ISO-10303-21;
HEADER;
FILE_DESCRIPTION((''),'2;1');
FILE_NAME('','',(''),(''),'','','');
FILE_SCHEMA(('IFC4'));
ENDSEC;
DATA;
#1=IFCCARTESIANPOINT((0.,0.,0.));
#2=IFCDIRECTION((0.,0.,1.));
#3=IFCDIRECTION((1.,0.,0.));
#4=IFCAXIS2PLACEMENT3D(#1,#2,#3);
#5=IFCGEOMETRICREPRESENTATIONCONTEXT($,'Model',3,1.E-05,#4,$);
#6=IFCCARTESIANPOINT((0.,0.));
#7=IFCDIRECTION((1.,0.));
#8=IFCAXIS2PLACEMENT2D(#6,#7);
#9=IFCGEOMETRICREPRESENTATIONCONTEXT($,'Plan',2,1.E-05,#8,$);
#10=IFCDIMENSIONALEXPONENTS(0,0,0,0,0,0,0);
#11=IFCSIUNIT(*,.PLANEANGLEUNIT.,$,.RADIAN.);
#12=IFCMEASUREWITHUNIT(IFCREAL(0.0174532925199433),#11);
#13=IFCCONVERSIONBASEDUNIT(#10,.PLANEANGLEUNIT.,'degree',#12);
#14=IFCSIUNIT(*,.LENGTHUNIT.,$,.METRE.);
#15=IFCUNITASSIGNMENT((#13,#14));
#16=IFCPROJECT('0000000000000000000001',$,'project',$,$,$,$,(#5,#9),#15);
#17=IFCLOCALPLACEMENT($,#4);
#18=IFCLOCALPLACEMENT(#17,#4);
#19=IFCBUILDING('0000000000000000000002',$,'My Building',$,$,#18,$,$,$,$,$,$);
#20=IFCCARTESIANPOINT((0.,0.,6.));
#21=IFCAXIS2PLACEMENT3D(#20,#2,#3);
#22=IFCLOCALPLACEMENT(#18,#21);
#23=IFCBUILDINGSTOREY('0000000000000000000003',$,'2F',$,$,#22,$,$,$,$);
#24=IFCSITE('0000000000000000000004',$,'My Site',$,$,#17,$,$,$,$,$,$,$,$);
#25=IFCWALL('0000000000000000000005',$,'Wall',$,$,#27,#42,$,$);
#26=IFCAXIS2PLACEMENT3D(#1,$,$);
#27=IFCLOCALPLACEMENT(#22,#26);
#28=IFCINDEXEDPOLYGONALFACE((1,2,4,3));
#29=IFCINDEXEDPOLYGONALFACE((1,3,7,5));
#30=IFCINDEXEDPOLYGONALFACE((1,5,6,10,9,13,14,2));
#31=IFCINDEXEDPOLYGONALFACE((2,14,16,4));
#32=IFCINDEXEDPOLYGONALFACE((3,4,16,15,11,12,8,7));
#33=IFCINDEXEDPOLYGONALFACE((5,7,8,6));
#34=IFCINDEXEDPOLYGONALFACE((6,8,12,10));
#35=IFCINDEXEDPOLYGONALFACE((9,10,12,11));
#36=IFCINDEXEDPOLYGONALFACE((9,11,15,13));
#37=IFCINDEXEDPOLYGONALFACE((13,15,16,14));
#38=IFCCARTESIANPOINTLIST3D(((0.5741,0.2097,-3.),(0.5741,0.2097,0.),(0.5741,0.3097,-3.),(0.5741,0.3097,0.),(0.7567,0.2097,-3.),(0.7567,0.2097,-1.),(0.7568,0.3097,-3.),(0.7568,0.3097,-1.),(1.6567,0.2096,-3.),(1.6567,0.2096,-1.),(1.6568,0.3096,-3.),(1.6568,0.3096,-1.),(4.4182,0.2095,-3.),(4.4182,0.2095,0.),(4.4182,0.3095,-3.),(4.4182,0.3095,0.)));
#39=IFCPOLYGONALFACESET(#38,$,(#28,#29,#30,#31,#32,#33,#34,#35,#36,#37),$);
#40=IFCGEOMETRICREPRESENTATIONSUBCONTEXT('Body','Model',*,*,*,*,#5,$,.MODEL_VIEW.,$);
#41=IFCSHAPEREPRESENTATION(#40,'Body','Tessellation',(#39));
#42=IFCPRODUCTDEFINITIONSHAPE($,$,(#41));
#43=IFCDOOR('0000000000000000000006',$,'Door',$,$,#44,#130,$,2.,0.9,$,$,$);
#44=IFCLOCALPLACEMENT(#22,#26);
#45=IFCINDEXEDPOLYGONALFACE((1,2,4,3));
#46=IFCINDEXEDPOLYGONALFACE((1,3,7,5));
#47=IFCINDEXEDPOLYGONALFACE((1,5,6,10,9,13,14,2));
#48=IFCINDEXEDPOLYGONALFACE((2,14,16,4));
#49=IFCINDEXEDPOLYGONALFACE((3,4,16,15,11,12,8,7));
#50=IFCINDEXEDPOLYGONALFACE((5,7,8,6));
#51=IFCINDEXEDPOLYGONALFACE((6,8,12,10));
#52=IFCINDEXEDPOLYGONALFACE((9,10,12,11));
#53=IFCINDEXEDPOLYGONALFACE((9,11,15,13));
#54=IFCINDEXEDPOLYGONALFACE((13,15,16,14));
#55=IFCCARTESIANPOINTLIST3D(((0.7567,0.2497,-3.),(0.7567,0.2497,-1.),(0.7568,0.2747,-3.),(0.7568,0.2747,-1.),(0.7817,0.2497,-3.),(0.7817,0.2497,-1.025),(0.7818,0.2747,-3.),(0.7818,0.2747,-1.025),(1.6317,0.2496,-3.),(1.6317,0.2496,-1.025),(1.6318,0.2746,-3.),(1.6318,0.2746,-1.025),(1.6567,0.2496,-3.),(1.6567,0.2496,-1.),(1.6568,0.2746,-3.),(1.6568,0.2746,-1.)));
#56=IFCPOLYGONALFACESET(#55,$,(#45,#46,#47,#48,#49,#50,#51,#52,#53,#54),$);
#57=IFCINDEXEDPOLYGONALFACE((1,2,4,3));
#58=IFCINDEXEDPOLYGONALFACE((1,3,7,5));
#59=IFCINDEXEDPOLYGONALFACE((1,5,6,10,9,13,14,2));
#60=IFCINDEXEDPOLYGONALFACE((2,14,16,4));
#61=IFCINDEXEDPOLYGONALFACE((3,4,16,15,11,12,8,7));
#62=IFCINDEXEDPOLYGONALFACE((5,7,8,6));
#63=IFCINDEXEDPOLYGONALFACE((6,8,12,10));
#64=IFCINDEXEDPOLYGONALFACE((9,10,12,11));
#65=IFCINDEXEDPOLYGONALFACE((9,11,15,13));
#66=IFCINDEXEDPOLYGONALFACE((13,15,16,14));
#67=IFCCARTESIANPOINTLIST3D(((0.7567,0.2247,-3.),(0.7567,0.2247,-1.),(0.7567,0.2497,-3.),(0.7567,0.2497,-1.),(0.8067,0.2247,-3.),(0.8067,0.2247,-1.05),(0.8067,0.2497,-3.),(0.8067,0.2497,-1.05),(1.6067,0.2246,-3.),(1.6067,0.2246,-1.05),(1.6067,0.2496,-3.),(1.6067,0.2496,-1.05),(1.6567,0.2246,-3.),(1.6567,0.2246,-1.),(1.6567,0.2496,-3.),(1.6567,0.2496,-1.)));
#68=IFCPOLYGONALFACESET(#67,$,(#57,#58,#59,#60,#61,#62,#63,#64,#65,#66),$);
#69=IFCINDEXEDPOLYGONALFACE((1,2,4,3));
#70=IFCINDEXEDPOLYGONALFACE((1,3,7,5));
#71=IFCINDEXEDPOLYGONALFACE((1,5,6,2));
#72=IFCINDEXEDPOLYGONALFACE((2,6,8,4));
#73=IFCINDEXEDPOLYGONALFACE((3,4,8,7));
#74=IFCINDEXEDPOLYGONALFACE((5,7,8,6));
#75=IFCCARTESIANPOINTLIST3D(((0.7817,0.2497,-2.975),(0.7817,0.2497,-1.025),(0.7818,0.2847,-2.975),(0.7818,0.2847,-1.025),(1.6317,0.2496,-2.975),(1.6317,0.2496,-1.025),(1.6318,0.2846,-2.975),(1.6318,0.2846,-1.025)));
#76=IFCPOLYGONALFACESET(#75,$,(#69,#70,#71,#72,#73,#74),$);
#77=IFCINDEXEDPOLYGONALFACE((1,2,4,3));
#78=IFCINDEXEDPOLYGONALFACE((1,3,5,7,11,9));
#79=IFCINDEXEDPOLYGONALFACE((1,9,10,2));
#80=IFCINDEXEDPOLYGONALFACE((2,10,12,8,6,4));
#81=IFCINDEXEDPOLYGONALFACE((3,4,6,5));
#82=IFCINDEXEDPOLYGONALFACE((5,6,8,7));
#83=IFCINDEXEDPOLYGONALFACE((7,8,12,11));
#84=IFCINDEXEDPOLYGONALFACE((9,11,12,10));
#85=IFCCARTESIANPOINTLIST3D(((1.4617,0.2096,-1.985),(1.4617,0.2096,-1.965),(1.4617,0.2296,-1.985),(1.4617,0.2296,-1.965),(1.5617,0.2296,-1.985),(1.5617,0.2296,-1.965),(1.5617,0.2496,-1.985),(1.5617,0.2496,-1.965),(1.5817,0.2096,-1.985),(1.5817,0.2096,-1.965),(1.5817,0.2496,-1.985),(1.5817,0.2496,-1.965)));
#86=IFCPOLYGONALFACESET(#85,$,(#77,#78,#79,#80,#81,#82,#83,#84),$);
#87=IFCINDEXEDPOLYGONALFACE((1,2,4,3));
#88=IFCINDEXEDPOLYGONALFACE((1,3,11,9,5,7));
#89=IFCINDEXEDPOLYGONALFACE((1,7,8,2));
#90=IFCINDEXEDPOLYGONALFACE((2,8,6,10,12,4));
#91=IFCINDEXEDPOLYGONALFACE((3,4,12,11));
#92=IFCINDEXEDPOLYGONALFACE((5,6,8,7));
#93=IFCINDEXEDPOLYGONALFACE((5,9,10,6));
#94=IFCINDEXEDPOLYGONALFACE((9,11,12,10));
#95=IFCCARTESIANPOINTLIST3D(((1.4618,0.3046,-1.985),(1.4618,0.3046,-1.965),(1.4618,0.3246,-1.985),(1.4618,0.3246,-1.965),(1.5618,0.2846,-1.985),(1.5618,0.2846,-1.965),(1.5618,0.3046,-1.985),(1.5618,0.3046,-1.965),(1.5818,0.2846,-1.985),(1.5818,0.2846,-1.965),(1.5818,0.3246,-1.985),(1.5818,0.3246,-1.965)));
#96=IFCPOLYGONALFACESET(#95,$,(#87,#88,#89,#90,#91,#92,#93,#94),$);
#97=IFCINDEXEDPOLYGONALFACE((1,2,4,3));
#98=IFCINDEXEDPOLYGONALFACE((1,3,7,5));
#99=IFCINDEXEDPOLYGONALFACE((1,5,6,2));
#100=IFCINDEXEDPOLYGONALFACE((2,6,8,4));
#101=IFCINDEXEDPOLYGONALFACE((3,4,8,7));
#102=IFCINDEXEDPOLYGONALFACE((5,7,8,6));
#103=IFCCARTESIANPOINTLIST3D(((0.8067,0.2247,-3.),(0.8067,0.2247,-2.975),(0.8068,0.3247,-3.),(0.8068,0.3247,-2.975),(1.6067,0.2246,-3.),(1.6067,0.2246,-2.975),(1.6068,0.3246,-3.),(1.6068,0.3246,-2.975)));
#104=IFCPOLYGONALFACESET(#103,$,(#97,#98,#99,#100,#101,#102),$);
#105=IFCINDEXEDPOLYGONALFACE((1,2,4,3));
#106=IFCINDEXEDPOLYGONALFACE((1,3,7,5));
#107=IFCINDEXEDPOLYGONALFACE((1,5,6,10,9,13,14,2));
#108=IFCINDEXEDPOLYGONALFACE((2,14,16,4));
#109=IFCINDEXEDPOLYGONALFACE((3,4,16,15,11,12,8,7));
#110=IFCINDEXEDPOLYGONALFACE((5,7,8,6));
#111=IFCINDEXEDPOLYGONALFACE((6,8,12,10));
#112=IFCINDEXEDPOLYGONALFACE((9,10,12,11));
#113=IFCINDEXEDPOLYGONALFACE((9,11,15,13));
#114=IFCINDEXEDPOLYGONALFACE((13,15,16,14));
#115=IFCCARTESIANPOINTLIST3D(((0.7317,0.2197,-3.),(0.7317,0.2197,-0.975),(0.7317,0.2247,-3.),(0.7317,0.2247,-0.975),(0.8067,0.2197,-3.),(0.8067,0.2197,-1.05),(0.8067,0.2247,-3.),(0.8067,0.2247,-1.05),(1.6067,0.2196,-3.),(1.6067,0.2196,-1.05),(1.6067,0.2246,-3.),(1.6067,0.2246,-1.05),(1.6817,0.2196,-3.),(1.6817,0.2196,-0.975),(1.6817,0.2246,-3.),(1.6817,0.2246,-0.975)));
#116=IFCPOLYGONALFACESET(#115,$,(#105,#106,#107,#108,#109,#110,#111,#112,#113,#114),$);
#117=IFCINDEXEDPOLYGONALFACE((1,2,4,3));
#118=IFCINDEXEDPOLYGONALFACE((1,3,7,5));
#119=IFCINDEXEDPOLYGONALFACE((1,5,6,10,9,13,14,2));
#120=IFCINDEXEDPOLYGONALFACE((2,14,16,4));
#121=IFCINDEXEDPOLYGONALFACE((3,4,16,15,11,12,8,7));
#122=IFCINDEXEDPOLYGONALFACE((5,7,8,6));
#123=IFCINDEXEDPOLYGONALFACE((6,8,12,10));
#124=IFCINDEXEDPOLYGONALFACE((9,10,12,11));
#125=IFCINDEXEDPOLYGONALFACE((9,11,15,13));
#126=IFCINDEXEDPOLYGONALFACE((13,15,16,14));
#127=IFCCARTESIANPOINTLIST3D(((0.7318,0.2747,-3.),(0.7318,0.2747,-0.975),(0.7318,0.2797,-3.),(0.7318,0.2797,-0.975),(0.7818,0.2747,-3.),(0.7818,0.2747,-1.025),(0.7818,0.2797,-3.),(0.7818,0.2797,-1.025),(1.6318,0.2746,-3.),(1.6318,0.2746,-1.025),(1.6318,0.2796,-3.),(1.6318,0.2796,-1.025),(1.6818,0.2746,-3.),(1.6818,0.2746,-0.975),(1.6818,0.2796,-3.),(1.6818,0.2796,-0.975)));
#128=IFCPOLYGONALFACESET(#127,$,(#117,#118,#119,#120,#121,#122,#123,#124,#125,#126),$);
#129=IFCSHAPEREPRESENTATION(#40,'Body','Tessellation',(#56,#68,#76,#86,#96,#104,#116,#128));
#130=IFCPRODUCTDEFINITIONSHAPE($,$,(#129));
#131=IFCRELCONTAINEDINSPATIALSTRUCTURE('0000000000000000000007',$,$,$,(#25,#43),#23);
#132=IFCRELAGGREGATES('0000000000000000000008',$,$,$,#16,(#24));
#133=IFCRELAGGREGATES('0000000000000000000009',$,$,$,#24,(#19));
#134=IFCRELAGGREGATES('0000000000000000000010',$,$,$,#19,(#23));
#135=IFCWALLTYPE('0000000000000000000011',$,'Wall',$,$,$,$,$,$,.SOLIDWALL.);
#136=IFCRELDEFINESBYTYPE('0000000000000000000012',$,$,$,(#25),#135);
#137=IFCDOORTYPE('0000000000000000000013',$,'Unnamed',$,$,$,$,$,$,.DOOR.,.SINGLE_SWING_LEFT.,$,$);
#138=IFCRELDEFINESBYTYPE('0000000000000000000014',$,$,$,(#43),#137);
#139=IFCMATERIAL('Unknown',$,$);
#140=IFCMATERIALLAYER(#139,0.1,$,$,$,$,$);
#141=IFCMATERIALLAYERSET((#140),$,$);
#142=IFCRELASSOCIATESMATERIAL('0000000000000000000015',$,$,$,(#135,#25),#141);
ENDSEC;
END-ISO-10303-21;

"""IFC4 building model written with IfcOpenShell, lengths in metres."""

from ifc_helpers import new_model, entity, si_unit, converted_unit, frame, origin_with_axes, origin_2d_with_axis, place, context, subcontext, project, spatial, line, indexed_curve, outline, extrude, shape, source, transform, mapped, material, layer, layer_set, layer_usage, type_object, type_shapes, element, fill, save


model = new_model("IFC4")

# Units and contexts
model_context = context("Model", 3, precision=1e-05, world=origin_with_axes())
plan_context = context("Plan", 2, precision=1e-05, world=origin_2d_with_axis())
body_context_1 = subcontext(model_context, "Body", "Model", "MODEL_VIEW")
body_context_2 = subcontext(plan_context, "Body", "Plan", "PLAN_VIEW")
ifc_project = project(units=[converted_unit("PLANEANGLEUNIT", "degree", entity("IfcReal", 0.0174532925199433), si_unit("PLANEANGLEUNIT", "RADIAN"), dimensions=[0, 0, 0, 0, 0, 0, 0]), si_unit("LENGTHUNIT", "METRE")], contexts=[model_context, plan_context])

# Site, building, storey
site_placement = place(None, origin_with_axes())
site = spatial("IfcSite", under=ifc_project, at=site_placement, Name="My Site")
building_placement = place(site_placement, origin_with_axes())
building = spatial("IfcBuilding", under=site, at=building_placement, Name="My Building")
storey_placement = place(building_placement, frame((0.0, 0.0, 6.0), z_axis=(0.0, 0.0, 1.0), x_axis=(1.0, 0.0, 0.0)))
storey = spatial("IfcBuildingStorey", under=building, at=storey_placement, Name="2F")

# Shared definitions
ifc_material = material(Name="Unknown")

# Shared definitions
ifc_layer_1 = layer(ifc_material, 0.1)
ifc_layer_set_1 = layer_set([ifc_layer_1])
wall_type = type_object("IfcWallType", Name="Wall", PredefinedType="SOLIDWALL", material=ifc_layer_set_1)
shared_shape_1 = source(origin_with_axes(), body_context_1, "Body", "SweptSolid", [
    extrude(outline(indexed_curve([(0.0, 0.0), (0.9, 0.0), (0.9, 2.0), (0.0, 2.0)], segments=[line(1, 2, 3, 4, 1)])), frame((0.0, -0.6, 0.0), z_axis=(0.0, -1.0, 0.0), x_axis=(1.0, 0.0, 0.0)), (0.0, 0.0, -1.0), 1.2),
])
door_type = type_object("IfcDoorType", Name="Unnamed", OperationType="SINGLE_SWING_LEFT", PredefinedType="DOOR")
shared_shape_2 = source(origin_with_axes(), body_context_1, "Body", "SweptSolid", [
    extrude(outline(indexed_curve([(0.0, 0.0), (0.0, 2.0), (0.9, 2.0), (0.9, 0.0), (0.875, 0.0), (0.875, 1.975), (0.025, 1.975), (0.025, 0.0)], segments=[line(1, 2, 3, 4, 5, 6, 7, 8, 1)])), frame((0.0, 0.025, 0.0), z_axis=(0.0, -1.0, 0.0), x_axis=(1.0, 0.0, 0.0)), (0.0, 0.0, -1.0), 0.025),
    extrude(outline(indexed_curve([(0.0, 0.0), (0.0, 2.0), (0.9, 2.0), (0.9, 0.0), (0.85, 0.0), (0.85, 1.95), (0.05, 1.95), (0.05, 0.0)], segments=[line(1, 2, 3, 4, 5, 6, 7, 8, 1)])), frame((0.0, 0.0, 0.0), z_axis=(0.0, -1.0, 0.0), x_axis=(1.0, 0.0, 0.0)), (0.0, 0.0, -1.0), 0.025),
    extrude(outline(indexed_curve([(0.0, 0.0), (0.85, 0.0), (0.85, 0.035), (0.0, 0.035)], segments=[line(1, 2, 3, 4, 1)])), frame((0.025, 0.025, 0.025), z_axis=(0.0, 0.0, 1.0), x_axis=(1.0, 0.0, 0.0)), (0.0, 0.0, 1.0), 1.95),
    extrude(outline(indexed_curve([(0.0, 0.0), (0.0, -0.04), (-0.12, -0.04), (-0.12, -0.02), (-0.02, -0.02), (-0.02, 0.0)], segments=[line(1, 2, 3, 4, 5, 6, 1)])), frame((0.825, 0.025, 1.015), z_axis=(0.0, 0.0, 1.0), x_axis=(1.0, 0.0, 0.0)), (0.0, 0.0, 1.0), 0.02),
    extrude(outline(indexed_curve([(0.0, 0.0), (0.0, 0.04), (-0.12, 0.04), (-0.12, 0.02), (-0.02, 0.02), (-0.02, 0.0)], segments=[line(1, 2, 3, 4, 5, 6, 1)])), frame((0.825, 0.06, 1.015), z_axis=(0.0, 0.0, 1.0), x_axis=(1.0, 0.0, 0.0)), (0.0, 0.0, 1.0), 0.02),
    extrude(outline(indexed_curve([(0.0, 0.0), (0.8, 0.0), (0.8, 0.1), (0.0, 0.1)], segments=[line(1, 2, 3, 4, 1)])), frame((0.05, 0.0, 0.0), z_axis=(0.0, 0.0, 1.0), x_axis=(1.0, 0.0, 0.0)), (0.0, 0.0, 1.0), 0.025),
    extrude(outline(indexed_curve([(0.0, 0.0), (0.0, 2.025), (0.95, 2.025), (0.95, 0.0), (0.875, 0.0), (0.875, 1.95), (0.075, 1.95), (0.075, 0.0)], segments=[line(1, 2, 3, 4, 5, 6, 7, 8, 1)])), frame((-0.025, -0.005, 0.0), z_axis=(0.0, -1.0, 0.0), x_axis=(1.0, 0.0, 0.0)), (0.0, 0.0, -1.0), 0.005),
    extrude(outline(indexed_curve([(0.0, 0.0), (0.0, 2.025), (0.95, 2.025), (0.95, 0.0), (0.9, 0.0), (0.9, 1.975), (0.05, 1.975), (0.05, 0.0)], segments=[line(1, 2, 3, 4, 5, 6, 7, 8, 1)])), frame((-0.025, 0.05, 0.0), z_axis=(0.0, -1.0, 0.0), x_axis=(1.0, 0.0, 0.0)), (0.0, 0.0, -1.0), 0.005),
])
shared_shape_3 = source(origin_with_axes(), body_context_2, "Body", "Curve2D", [
    entity("IfcIndexedPolyCurve", entity("IfcCartesianPointList2D", [[0.0, 0.0], [0.0, 0.05], [0.025, 0.05], [0.025, 0.025], [0.05, 0.025], [0.05, 0.0]]), [entity("IfcLineIndex", [1, 2, 3, 4, 5, 6, 1])]),
    entity("IfcIndexedPolyCurve", entity("IfcCartesianPointList2D", [[0.9, 0.0], [0.9, 0.05], [0.875, 0.05], [0.875, 0.025], [0.85, 0.025], [0.85, 0.0]]), [entity("IfcLineIndex", [1, 2, 3, 4, 5, 6, 1])]),
    entity("IfcTrimmedCurve", entity("IfcEllipse", entity("IfcAxis2Placement2D", entity("IfcCartesianPoint", [0.06, 0.05]), entity("IfcDirection", [1.0, 0.0])), 0.815, 0.85), [entity("IfcCartesianPoint", [0.875, 0.05])], [entity("IfcCartesianPoint", [0.06, 0.9])], True, "CARTESIAN"),
    entity("IfcIndexedPolyCurve", entity("IfcCartesianPointList2D", [[0.025, 0.05], [0.06, 0.05], [0.06, 0.9], [0.025, 0.9]]), [entity("IfcLineIndex", [1, 2, 3, 4, 1])]),
])
type_shapes(door_type, [shared_shape_2, shared_shape_3])

# Wall, opening, door
ifc_layer_usage_1 = layer_usage(ifc_layer_set_1, "AXIS2", "POSITIVE", 0.0)
wall_1_placement = place(storey_placement, frame((4.4182, 0.3095, -3.0), z_axis=(0.0, 0.0, 1.0), x_axis=(-1.0, 0.000045, 0.0)))
wall_1 = element("IfcWall", 1, at=wall_1_placement, inside=storey, type_object=wall_type, material=ifc_layer_usage_1, Name="Wall", context=body_context_1, shape_type="SweptSolid", body=[
    extrude(outline(indexed_curve([(0.0, 0.0), (0.0, 0.1), (3.8441, 0.1), (3.8441, 0.0)], segments=[line(1, 2, 3, 4, 1)])), origin_with_axes(), (0.0, 0.0, 1.0), 3.0),
])
opening_1_placement = place(wall_1_placement, frame((2.7615, 0.0, 0.0), z_axis=(0.0, 0.0, 1.0), x_axis=(1.0, 0.0, 0.0)))
opening_1 = element("IfcOpeningElement", 2, at=opening_1_placement, cuts=wall_1, PredefinedType="OPENING", context=body_context_1, shape_type="MappedRepresentation", body=[
    mapped(shared_shape_1, transform((0.0, 0.0, 0.0), x_axis=(1.0, 0.0, 0.0), y_axis=(0.0, 1.0, 0.0), z_axis=(0.0, 0.0, 1.0), scale=1.0)),
])
door_1_placement = place(opening_1_placement, frame((0.9, 0.085, 0.0), z_axis=(0.0, 0.0, 1.0), x_axis=(-1.0, 0.0, 0.0)))
door_1 = element("IfcDoor", 3, at=door_1_placement, inside=storey, type_object=door_type, Name="Door", OverallHeight=2.0, OverallWidth=0.9, shapes=[
    shape(body_context_1, "Body", "MappedRepresentation", [mapped(shared_shape_2, transform((0.0, 0.0, 0.0), x_axis=(1.0, 0.0, 0.0), y_axis=(0.0, 1.0, 0.0), z_axis=(0.0, 0.0, 1.0), scale=1.0))]),
    shape(body_context_2, "Body", "MappedRepresentation", [mapped(shared_shape_3, transform((0.0, 0.0, 0.0), x_axis=(1.0, 0.0, 0.0), y_axis=(0.0, 1.0, 0.0), z_axis=(0.0, 0.0, 1.0), scale=1.0))]),
])
fill(opening_1, door_1)

save(model, "model.ifc")
